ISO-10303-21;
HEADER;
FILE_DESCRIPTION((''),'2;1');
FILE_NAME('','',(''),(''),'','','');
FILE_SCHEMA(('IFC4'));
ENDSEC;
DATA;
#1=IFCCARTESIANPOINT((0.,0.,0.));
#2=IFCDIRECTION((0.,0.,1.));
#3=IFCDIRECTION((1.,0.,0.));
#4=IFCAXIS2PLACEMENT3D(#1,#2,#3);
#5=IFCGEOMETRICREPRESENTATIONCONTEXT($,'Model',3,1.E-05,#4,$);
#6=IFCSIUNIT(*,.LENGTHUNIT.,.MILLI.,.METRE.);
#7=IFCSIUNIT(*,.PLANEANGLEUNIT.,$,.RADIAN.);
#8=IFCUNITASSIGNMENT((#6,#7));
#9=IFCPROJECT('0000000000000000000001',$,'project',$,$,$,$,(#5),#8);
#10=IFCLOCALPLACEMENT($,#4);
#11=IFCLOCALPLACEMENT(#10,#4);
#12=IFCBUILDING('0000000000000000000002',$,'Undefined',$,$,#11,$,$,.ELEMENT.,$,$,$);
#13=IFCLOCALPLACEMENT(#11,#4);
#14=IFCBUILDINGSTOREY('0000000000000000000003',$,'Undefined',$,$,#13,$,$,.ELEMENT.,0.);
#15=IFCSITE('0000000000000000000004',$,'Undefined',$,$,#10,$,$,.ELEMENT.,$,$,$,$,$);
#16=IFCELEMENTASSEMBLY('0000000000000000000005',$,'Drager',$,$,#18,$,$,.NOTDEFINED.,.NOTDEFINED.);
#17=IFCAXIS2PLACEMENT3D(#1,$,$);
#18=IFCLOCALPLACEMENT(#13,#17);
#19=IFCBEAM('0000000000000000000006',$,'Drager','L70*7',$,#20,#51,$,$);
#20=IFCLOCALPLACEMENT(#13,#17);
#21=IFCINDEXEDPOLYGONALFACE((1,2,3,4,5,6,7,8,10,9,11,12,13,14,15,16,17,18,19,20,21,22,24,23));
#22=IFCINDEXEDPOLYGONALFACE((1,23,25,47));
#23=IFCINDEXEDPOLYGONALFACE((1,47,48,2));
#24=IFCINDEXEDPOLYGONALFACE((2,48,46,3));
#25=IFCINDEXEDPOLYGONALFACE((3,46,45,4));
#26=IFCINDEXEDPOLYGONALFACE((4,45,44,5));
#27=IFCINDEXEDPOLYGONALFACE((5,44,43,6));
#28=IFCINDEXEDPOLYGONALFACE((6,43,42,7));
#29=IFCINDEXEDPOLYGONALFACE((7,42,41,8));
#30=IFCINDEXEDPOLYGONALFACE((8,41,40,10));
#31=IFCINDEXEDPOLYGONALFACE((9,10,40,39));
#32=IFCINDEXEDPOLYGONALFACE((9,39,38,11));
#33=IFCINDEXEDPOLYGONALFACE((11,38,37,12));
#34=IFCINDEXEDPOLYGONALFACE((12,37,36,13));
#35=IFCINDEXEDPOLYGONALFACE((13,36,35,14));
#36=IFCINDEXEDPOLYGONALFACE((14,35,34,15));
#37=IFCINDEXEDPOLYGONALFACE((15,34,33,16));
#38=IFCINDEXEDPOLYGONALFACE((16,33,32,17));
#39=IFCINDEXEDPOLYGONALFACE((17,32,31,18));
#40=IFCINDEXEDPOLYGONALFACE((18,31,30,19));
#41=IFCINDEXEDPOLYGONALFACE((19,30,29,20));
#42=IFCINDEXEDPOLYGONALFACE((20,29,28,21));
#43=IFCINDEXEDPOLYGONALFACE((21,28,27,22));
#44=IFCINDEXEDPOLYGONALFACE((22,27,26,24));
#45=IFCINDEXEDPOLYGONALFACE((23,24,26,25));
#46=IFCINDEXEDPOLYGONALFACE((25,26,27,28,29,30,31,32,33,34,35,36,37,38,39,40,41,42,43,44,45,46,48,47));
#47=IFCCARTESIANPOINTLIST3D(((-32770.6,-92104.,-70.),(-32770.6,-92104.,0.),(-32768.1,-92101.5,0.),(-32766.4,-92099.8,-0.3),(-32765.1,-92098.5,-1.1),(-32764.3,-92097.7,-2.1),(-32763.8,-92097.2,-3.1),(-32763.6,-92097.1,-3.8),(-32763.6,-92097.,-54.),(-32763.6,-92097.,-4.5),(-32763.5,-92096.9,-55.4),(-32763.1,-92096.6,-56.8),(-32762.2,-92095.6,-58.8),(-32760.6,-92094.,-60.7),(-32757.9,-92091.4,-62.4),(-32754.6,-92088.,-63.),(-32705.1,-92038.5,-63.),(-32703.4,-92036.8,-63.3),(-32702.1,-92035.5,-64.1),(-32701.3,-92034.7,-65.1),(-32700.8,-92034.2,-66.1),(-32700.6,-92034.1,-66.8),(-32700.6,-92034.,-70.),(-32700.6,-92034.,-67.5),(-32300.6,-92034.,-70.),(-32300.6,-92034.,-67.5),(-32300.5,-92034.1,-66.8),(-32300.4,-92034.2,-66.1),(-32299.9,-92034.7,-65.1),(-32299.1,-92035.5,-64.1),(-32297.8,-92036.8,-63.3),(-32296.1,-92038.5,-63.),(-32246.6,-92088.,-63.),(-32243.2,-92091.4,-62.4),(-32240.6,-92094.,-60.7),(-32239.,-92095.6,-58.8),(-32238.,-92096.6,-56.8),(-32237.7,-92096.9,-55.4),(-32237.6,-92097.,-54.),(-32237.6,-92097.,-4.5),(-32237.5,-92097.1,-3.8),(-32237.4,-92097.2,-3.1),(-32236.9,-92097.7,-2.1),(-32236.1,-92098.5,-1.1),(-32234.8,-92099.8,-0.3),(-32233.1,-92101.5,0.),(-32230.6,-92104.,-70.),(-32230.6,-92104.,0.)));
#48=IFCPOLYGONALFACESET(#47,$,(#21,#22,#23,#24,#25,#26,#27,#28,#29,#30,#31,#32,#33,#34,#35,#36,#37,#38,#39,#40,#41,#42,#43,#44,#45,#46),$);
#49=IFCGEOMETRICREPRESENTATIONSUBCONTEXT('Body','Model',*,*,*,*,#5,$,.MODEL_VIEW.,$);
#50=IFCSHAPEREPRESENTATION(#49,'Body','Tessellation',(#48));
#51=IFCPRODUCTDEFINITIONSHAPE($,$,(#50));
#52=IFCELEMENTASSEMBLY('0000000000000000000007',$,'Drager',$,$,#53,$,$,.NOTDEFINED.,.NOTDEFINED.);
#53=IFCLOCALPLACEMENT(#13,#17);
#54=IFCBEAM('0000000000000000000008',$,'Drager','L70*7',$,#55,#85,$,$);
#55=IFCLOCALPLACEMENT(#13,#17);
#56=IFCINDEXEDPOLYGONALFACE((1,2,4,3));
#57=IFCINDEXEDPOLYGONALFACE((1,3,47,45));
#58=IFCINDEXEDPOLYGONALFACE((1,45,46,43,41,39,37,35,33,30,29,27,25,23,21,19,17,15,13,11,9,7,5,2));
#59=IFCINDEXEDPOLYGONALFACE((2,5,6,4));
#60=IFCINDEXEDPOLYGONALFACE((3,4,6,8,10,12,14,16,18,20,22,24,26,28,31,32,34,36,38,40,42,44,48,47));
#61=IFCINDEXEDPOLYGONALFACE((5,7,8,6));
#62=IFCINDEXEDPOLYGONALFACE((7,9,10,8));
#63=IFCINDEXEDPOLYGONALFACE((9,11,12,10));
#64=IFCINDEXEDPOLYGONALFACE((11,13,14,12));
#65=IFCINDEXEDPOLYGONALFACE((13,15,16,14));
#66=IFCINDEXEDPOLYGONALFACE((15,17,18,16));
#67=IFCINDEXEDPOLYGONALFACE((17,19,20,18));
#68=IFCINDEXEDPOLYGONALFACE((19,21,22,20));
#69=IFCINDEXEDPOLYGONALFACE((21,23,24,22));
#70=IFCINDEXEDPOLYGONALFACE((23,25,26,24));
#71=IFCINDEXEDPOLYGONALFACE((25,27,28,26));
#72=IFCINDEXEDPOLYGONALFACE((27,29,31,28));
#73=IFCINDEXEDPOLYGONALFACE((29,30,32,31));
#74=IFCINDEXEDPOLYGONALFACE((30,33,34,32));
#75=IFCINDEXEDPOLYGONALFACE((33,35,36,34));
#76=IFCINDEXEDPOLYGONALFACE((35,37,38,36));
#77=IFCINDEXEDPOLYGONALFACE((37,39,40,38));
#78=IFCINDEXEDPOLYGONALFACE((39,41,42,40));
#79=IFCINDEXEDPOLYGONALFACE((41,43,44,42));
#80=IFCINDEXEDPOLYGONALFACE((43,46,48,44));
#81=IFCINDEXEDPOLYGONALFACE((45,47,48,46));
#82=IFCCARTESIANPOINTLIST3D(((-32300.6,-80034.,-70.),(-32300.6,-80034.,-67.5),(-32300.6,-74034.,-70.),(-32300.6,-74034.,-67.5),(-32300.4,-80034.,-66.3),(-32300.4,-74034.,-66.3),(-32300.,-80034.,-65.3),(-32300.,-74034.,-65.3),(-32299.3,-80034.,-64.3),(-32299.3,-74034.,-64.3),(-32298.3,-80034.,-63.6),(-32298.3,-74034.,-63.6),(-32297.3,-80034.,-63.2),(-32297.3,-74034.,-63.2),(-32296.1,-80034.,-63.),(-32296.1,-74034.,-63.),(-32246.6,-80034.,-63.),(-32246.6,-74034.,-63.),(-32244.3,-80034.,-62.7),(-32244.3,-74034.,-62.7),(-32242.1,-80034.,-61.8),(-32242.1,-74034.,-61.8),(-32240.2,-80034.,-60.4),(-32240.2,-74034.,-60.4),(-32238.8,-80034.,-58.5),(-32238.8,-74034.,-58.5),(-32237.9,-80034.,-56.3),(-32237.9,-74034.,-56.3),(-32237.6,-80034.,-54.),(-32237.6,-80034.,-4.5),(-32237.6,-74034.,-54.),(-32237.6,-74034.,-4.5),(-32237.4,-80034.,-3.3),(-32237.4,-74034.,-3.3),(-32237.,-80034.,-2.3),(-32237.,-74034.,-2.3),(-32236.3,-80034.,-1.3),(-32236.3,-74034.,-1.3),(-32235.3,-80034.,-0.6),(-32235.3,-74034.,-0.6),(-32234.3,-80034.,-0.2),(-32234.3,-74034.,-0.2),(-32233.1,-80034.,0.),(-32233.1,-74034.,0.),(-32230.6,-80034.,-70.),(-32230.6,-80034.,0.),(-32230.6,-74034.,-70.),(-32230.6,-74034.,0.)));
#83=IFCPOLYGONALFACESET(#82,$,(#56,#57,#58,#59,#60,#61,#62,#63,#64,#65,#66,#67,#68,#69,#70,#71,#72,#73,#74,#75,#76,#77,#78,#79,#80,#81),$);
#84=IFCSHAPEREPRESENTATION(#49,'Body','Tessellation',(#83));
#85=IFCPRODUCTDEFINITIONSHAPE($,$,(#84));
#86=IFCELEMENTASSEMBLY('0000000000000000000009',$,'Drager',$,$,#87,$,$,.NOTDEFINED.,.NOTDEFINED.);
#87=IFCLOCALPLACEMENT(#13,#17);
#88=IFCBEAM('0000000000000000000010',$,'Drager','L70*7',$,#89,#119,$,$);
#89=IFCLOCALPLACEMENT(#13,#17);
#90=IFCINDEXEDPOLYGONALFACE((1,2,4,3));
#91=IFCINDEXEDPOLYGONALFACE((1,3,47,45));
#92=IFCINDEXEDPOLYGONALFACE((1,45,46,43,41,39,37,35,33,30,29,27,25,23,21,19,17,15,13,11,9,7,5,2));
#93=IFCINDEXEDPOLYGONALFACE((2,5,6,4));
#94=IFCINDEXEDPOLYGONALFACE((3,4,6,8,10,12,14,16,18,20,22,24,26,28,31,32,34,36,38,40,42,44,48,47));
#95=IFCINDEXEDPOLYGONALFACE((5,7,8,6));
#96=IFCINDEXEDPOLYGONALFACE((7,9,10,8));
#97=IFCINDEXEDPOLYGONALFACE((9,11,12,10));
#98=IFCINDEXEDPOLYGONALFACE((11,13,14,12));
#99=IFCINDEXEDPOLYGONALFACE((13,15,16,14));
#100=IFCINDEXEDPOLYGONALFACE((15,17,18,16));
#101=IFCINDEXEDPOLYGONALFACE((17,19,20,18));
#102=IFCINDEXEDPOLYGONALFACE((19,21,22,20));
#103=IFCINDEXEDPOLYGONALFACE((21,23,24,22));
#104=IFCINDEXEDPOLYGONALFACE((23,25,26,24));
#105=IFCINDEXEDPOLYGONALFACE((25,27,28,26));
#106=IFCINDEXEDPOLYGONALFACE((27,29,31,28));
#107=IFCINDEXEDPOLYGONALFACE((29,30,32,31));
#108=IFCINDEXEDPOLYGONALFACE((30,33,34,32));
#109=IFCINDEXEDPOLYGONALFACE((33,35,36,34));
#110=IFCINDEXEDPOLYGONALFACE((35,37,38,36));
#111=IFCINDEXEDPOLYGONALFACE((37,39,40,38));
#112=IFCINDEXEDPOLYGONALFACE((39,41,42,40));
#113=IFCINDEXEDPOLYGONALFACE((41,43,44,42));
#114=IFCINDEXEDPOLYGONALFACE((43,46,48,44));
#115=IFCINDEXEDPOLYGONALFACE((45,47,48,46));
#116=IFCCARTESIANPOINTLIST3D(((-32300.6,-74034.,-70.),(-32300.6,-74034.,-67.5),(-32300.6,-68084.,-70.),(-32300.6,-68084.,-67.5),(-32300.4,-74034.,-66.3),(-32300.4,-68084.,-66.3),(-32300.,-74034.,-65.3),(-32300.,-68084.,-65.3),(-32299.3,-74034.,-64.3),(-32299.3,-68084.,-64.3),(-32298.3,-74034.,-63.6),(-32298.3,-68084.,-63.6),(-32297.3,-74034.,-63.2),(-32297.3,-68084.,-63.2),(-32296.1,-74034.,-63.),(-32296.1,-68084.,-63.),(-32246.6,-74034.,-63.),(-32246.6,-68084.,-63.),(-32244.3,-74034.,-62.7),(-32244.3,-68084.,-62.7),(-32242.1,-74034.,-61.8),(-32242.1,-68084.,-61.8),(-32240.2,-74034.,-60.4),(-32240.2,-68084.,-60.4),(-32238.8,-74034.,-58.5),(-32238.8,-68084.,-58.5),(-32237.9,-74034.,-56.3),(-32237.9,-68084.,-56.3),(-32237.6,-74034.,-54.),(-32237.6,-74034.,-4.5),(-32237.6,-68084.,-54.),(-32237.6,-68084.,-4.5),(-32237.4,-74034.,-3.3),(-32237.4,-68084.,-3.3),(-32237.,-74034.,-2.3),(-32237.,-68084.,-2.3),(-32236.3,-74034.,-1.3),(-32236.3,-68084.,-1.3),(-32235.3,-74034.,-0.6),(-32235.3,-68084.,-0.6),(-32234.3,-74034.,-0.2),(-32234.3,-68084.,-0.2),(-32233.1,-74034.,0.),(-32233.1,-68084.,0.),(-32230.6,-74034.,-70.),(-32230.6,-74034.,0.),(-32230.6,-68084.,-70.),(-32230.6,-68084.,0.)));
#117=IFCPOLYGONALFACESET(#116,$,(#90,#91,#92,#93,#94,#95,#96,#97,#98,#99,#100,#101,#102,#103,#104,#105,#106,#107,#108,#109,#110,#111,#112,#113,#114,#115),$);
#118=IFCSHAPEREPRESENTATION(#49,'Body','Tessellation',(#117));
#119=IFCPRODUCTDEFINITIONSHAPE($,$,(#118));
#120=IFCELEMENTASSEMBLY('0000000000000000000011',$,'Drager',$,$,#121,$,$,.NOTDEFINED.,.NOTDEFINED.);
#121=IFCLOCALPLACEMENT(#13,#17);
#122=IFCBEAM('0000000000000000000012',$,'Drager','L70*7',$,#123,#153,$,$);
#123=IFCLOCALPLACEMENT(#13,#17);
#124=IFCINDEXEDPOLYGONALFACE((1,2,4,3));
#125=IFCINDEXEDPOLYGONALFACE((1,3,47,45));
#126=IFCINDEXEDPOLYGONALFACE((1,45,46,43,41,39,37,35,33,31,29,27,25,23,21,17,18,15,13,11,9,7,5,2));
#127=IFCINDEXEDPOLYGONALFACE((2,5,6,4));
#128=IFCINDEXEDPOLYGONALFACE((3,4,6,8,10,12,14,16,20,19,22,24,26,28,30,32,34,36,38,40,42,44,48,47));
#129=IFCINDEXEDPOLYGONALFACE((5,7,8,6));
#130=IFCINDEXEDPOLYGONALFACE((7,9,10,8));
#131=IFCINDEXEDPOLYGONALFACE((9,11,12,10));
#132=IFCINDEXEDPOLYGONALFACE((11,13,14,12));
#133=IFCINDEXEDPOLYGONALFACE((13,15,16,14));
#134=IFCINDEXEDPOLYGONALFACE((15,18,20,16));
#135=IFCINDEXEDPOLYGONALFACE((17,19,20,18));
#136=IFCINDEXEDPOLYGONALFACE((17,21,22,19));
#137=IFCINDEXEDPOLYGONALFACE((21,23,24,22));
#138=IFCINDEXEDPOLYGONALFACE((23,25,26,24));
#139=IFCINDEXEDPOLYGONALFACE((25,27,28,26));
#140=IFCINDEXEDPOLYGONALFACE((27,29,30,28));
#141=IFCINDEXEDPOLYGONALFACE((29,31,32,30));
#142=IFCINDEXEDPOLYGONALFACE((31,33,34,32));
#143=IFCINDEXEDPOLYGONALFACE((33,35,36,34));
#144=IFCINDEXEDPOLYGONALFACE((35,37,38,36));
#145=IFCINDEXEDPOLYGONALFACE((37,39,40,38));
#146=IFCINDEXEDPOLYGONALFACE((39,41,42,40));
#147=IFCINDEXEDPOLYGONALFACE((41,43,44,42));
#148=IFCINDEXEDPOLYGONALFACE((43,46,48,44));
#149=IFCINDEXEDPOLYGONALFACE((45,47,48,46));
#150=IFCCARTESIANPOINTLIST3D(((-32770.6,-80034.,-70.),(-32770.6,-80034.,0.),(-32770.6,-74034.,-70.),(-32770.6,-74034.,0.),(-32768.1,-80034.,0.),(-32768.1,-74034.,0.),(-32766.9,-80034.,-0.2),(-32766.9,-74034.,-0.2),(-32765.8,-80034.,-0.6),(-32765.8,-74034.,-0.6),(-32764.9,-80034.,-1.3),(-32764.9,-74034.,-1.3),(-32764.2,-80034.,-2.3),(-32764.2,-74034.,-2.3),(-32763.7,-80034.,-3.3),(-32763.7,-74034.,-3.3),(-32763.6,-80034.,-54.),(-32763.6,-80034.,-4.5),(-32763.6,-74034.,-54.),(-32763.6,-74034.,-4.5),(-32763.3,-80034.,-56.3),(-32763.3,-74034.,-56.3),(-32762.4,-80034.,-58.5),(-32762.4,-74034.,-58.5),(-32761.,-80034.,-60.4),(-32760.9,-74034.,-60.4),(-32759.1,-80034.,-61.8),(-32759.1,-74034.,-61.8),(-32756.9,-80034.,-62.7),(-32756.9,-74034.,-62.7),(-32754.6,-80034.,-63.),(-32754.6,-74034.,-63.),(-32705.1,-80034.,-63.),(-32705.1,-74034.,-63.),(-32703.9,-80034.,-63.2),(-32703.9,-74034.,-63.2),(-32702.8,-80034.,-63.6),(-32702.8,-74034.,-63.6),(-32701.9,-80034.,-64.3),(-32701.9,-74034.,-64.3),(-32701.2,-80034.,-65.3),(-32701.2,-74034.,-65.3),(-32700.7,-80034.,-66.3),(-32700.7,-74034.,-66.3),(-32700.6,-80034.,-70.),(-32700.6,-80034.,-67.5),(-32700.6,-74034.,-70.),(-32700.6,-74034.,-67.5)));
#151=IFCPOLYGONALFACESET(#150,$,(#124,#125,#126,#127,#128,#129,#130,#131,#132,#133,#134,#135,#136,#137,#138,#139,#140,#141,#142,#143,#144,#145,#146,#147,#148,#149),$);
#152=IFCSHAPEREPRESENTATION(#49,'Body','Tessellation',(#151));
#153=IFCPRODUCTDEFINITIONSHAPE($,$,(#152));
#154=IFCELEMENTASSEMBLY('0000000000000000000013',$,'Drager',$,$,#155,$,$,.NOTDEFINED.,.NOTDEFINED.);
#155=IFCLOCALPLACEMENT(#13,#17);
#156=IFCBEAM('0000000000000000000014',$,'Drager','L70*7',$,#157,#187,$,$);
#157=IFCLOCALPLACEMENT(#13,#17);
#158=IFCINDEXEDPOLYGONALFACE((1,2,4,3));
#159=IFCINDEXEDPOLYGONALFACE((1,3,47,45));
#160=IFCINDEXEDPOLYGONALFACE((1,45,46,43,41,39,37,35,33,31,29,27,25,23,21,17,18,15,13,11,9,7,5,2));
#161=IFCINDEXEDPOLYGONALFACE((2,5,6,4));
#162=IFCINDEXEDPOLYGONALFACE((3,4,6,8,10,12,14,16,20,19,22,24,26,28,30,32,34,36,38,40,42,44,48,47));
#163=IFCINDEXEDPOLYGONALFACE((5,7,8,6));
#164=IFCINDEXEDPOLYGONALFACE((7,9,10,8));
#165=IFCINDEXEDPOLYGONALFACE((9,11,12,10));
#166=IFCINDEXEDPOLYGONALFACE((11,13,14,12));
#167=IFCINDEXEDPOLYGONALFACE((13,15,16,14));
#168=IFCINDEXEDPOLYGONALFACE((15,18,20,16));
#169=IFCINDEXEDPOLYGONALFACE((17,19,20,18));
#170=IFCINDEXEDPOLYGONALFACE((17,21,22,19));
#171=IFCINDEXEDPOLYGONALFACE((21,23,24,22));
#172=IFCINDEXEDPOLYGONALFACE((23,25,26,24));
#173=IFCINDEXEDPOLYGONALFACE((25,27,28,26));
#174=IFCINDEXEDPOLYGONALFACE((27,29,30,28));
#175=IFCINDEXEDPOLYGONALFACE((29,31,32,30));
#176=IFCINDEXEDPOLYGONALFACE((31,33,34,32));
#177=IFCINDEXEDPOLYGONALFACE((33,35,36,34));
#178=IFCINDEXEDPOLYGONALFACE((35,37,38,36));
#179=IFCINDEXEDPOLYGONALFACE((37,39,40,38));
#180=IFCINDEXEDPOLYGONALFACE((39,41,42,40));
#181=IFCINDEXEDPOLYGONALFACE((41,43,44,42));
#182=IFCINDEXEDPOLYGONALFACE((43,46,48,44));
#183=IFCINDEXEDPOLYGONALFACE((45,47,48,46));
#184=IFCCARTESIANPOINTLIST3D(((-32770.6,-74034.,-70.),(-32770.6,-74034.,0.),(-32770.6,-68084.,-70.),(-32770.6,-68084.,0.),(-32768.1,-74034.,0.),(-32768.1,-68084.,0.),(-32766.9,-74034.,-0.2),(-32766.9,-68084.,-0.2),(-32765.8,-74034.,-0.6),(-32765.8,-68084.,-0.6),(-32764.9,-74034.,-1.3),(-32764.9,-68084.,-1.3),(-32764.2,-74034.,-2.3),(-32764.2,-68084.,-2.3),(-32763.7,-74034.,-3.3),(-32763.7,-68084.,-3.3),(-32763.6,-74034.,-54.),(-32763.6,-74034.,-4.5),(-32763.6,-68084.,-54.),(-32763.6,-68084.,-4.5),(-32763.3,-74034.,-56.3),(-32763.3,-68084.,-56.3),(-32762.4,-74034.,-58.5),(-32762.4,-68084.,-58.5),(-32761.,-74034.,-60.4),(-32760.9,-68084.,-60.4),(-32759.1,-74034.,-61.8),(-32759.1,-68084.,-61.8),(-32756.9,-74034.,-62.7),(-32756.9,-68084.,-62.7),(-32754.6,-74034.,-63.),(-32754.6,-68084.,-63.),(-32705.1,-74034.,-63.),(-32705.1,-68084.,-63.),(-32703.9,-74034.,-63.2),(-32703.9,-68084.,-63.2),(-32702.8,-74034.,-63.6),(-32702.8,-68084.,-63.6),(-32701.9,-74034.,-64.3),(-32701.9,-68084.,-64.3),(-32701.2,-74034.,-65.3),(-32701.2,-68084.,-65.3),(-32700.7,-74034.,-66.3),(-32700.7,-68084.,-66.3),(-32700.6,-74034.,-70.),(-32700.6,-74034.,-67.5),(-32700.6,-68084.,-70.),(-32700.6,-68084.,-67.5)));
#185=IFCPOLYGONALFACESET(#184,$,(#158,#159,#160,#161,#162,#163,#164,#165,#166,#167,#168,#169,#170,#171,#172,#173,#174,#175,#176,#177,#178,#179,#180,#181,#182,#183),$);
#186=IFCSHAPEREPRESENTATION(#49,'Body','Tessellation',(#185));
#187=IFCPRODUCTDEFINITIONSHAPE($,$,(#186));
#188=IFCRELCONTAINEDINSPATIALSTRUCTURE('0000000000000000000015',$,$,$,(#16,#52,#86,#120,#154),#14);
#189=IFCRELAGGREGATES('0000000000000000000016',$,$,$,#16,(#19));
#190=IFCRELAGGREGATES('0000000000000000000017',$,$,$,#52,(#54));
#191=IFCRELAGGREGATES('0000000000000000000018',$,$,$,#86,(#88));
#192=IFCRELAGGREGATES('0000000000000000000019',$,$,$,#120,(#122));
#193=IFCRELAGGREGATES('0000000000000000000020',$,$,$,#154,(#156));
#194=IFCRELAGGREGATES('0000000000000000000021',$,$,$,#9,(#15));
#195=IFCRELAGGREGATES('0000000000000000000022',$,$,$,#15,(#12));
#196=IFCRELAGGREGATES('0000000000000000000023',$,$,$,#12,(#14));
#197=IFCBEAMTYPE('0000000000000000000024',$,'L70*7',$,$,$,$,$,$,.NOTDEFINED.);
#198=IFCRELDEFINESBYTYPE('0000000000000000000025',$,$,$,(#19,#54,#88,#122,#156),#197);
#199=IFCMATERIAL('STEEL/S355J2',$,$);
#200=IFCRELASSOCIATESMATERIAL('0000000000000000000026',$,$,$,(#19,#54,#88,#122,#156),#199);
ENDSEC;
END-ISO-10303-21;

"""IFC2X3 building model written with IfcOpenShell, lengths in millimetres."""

from ifc_helpers import new_model, si_unit, frame, origin_with_axes, origin_2d_with_axis, place, context, subcontext, project, spatial, l_section, extrude, clip, halfspace, material, type_object, element, aggregate, save


model = new_model("IFC2X3")

# Units and contexts
model_context = context("Model", 3, precision=1e-05, world=origin_with_axes())
body_context = subcontext(model_context, "Body", "Model", "MODEL_VIEW")
ifc_project = project(units=[si_unit("LENGTHUNIT", "METRE", prefix="MILLI"), si_unit("PLANEANGLEUNIT", "RADIAN")], contexts=[model_context])

# Site, building, storey
site_placement = place(None, origin_with_axes())
site = spatial("IfcSite", under=ifc_project, at=site_placement, Name="Undefined", CompositionType="ELEMENT")
building_placement = place(site_placement, origin_with_axes())
building = spatial("IfcBuilding", under=site, at=building_placement, Name="Undefined", CompositionType="ELEMENT")
storey_placement = place(building_placement, origin_with_axes())
storey = spatial("IfcBuildingStorey", under=building, at=storey_placement, Name="Undefined", CompositionType="ELEMENT", Elevation=0.0)

# Shared definitions
ifc_material = material(Name="STEEL/S355J2")
beam_type = type_object("IfcBeamType", Name="L70*7", PredefinedType="NOTDEFINED")

# Element assembly
assembly_1_placement = place(storey_placement, origin_with_axes())
assembly_1 = element("IfcElementAssembly", 1, at=assembly_1_placement, inside=storey, Name="Drager", AssemblyPlace="NOTDEFINED", PredefinedType="NOTDEFINED")

# Beam
beam_1_placement = place(assembly_1_placement, frame((-32300.6, -92069.0, -35.0), z_axis=(0.0, 0.0, 1.0), x_axis=(-1.0, 0.0, 0.0)))
beam_1 = element("IfcBeam", 2, at=beam_1_placement, type_object=beam_type, material=ifc_material, Name="Drager", Description="L70*7", context=body_context, shape_type="Clipping", body=[
    clip(clip(extrude(l_section(Depth=70.0, Width=70.0, Thickness=7.0, FilletRadius=9.0, EdgeRadius=4.5, at=origin_2d_with_axis()), frame((505.7, 0.0, 0.0), z_axis=(-1.0, 0.0, 0.0), x_axis=(0.0, -1.0, 0.0)), (0.0, 0.0, 1.0), 611.4), halfspace(frame((400.0, -35.0, 35.0), z_axis=(0.707107, -0.707107, 0.0), x_axis=(0.0, 0.0, 1.0)), False)), halfspace(frame((0.0, -35.0, 35.0), z_axis=(0.707107, 0.707107, 0.0), x_axis=(0.0, 0.0, 1.0)), True)),
])
aggregate(assembly_1, [beam_1])

# Element assemblies, beams
assembly_2_placement = place(storey_placement, origin_with_axes())
assembly_2 = element("IfcElementAssembly", 3, at=assembly_2_placement, inside=storey, Name="Drager", AssemblyPlace="NOTDEFINED", PredefinedType="NOTDEFINED")
beam_2_placement = place(assembly_2_placement, frame((-32265.6, -74034.0, -35.0), z_axis=(0.0, 0.0, 1.0), x_axis=(0.0, -1.0, 0.0)))
beam_2 = element("IfcBeam", 4, at=beam_2_placement, type_object=beam_type, material=ifc_material, Name="Drager", Description="L70*7", context=body_context, shape_type="SweptSolid", body=[
    extrude(l_section(Depth=70.0, Width=70.0, Thickness=7.0, FilletRadius=9.0, EdgeRadius=4.5, at=origin_2d_with_axis()), frame((6000.0, 0.0, 0.0), z_axis=(-1.0, 0.0, 0.0), x_axis=(0.0, -1.0, 0.0)), (0.0, 0.0, 1.0), 6000.0),
])
aggregate(assembly_2, [beam_2])
assembly_3_placement = place(storey_placement, origin_with_axes())
assembly_3 = element("IfcElementAssembly", 5, at=assembly_3_placement, inside=storey, Name="Drager", AssemblyPlace="NOTDEFINED", PredefinedType="NOTDEFINED")
beam_3_placement = place(assembly_3_placement, frame((-32265.6, -68084.0, -35.0), z_axis=(0.0, 0.0, 1.0), x_axis=(0.0, -1.0, 0.0)))
beam_3 = element("IfcBeam", 6, at=beam_3_placement, type_object=beam_type, material=ifc_material, Name="Drager", Description="L70*7", context=body_context, shape_type="SweptSolid", body=[
    extrude(l_section(Depth=70.0, Width=70.0, Thickness=7.0, FilletRadius=9.0, EdgeRadius=4.5, at=origin_2d_with_axis()), frame((5950.0, 0.0, 0.0), z_axis=(-1.0, 0.0, 0.0), x_axis=(0.0, -1.0, 0.0)), (0.0, 0.0, 1.0), 5950.0),
])
aggregate(assembly_3, [beam_3])
assembly_4_placement = place(storey_placement, origin_with_axes())
assembly_4 = element("IfcElementAssembly", 7, at=assembly_4_placement, inside=storey, Name="Drager", AssemblyPlace="NOTDEFINED", PredefinedType="NOTDEFINED")
beam_4_placement = place(assembly_4_placement, frame((-32735.6, -80034.0, -35.0), z_axis=(0.0, 0.0, 1.0), x_axis=(0.0, 1.0, 0.0)))
beam_4 = element("IfcBeam", 8, at=beam_4_placement, type_object=beam_type, material=ifc_material, Name="Drager", Description="L70*7", context=body_context, shape_type="SweptSolid", body=[
    extrude(l_section(Depth=70.0, Width=70.0, Thickness=7.0, FilletRadius=9.0, EdgeRadius=4.5, at=origin_2d_with_axis()), frame((6000.0, 0.0, 0.0), z_axis=(-1.0, 0.0, 0.0), x_axis=(0.0, -1.0, 0.0)), (0.0, 0.0, 1.0), 6000.0),
])
aggregate(assembly_4, [beam_4])
assembly_5_placement = place(storey_placement, origin_with_axes())
assembly_5 = element("IfcElementAssembly", 9, at=assembly_5_placement, inside=storey, Name="Drager", AssemblyPlace="NOTDEFINED", PredefinedType="NOTDEFINED")
beam_5_placement = place(assembly_5_placement, frame((-32735.6, -74034.0, -35.0), z_axis=(0.0, 0.0, 1.0), x_axis=(0.0, 1.0, 0.0)))
beam_5 = element("IfcBeam", 10, at=beam_5_placement, type_object=beam_type, material=ifc_material, Name="Drager", Description="L70*7", context=body_context, shape_type="SweptSolid", body=[
    extrude(l_section(Depth=70.0, Width=70.0, Thickness=7.0, FilletRadius=9.0, EdgeRadius=4.5, at=origin_2d_with_axis()), frame((5950.0, 0.0, 0.0), z_axis=(-1.0, 0.0, 0.0), x_axis=(0.0, -1.0, 0.0)), (0.0, 0.0, 1.0), 5950.0),
])
aggregate(assembly_5, [beam_5])

save(model, "model.ifc")
